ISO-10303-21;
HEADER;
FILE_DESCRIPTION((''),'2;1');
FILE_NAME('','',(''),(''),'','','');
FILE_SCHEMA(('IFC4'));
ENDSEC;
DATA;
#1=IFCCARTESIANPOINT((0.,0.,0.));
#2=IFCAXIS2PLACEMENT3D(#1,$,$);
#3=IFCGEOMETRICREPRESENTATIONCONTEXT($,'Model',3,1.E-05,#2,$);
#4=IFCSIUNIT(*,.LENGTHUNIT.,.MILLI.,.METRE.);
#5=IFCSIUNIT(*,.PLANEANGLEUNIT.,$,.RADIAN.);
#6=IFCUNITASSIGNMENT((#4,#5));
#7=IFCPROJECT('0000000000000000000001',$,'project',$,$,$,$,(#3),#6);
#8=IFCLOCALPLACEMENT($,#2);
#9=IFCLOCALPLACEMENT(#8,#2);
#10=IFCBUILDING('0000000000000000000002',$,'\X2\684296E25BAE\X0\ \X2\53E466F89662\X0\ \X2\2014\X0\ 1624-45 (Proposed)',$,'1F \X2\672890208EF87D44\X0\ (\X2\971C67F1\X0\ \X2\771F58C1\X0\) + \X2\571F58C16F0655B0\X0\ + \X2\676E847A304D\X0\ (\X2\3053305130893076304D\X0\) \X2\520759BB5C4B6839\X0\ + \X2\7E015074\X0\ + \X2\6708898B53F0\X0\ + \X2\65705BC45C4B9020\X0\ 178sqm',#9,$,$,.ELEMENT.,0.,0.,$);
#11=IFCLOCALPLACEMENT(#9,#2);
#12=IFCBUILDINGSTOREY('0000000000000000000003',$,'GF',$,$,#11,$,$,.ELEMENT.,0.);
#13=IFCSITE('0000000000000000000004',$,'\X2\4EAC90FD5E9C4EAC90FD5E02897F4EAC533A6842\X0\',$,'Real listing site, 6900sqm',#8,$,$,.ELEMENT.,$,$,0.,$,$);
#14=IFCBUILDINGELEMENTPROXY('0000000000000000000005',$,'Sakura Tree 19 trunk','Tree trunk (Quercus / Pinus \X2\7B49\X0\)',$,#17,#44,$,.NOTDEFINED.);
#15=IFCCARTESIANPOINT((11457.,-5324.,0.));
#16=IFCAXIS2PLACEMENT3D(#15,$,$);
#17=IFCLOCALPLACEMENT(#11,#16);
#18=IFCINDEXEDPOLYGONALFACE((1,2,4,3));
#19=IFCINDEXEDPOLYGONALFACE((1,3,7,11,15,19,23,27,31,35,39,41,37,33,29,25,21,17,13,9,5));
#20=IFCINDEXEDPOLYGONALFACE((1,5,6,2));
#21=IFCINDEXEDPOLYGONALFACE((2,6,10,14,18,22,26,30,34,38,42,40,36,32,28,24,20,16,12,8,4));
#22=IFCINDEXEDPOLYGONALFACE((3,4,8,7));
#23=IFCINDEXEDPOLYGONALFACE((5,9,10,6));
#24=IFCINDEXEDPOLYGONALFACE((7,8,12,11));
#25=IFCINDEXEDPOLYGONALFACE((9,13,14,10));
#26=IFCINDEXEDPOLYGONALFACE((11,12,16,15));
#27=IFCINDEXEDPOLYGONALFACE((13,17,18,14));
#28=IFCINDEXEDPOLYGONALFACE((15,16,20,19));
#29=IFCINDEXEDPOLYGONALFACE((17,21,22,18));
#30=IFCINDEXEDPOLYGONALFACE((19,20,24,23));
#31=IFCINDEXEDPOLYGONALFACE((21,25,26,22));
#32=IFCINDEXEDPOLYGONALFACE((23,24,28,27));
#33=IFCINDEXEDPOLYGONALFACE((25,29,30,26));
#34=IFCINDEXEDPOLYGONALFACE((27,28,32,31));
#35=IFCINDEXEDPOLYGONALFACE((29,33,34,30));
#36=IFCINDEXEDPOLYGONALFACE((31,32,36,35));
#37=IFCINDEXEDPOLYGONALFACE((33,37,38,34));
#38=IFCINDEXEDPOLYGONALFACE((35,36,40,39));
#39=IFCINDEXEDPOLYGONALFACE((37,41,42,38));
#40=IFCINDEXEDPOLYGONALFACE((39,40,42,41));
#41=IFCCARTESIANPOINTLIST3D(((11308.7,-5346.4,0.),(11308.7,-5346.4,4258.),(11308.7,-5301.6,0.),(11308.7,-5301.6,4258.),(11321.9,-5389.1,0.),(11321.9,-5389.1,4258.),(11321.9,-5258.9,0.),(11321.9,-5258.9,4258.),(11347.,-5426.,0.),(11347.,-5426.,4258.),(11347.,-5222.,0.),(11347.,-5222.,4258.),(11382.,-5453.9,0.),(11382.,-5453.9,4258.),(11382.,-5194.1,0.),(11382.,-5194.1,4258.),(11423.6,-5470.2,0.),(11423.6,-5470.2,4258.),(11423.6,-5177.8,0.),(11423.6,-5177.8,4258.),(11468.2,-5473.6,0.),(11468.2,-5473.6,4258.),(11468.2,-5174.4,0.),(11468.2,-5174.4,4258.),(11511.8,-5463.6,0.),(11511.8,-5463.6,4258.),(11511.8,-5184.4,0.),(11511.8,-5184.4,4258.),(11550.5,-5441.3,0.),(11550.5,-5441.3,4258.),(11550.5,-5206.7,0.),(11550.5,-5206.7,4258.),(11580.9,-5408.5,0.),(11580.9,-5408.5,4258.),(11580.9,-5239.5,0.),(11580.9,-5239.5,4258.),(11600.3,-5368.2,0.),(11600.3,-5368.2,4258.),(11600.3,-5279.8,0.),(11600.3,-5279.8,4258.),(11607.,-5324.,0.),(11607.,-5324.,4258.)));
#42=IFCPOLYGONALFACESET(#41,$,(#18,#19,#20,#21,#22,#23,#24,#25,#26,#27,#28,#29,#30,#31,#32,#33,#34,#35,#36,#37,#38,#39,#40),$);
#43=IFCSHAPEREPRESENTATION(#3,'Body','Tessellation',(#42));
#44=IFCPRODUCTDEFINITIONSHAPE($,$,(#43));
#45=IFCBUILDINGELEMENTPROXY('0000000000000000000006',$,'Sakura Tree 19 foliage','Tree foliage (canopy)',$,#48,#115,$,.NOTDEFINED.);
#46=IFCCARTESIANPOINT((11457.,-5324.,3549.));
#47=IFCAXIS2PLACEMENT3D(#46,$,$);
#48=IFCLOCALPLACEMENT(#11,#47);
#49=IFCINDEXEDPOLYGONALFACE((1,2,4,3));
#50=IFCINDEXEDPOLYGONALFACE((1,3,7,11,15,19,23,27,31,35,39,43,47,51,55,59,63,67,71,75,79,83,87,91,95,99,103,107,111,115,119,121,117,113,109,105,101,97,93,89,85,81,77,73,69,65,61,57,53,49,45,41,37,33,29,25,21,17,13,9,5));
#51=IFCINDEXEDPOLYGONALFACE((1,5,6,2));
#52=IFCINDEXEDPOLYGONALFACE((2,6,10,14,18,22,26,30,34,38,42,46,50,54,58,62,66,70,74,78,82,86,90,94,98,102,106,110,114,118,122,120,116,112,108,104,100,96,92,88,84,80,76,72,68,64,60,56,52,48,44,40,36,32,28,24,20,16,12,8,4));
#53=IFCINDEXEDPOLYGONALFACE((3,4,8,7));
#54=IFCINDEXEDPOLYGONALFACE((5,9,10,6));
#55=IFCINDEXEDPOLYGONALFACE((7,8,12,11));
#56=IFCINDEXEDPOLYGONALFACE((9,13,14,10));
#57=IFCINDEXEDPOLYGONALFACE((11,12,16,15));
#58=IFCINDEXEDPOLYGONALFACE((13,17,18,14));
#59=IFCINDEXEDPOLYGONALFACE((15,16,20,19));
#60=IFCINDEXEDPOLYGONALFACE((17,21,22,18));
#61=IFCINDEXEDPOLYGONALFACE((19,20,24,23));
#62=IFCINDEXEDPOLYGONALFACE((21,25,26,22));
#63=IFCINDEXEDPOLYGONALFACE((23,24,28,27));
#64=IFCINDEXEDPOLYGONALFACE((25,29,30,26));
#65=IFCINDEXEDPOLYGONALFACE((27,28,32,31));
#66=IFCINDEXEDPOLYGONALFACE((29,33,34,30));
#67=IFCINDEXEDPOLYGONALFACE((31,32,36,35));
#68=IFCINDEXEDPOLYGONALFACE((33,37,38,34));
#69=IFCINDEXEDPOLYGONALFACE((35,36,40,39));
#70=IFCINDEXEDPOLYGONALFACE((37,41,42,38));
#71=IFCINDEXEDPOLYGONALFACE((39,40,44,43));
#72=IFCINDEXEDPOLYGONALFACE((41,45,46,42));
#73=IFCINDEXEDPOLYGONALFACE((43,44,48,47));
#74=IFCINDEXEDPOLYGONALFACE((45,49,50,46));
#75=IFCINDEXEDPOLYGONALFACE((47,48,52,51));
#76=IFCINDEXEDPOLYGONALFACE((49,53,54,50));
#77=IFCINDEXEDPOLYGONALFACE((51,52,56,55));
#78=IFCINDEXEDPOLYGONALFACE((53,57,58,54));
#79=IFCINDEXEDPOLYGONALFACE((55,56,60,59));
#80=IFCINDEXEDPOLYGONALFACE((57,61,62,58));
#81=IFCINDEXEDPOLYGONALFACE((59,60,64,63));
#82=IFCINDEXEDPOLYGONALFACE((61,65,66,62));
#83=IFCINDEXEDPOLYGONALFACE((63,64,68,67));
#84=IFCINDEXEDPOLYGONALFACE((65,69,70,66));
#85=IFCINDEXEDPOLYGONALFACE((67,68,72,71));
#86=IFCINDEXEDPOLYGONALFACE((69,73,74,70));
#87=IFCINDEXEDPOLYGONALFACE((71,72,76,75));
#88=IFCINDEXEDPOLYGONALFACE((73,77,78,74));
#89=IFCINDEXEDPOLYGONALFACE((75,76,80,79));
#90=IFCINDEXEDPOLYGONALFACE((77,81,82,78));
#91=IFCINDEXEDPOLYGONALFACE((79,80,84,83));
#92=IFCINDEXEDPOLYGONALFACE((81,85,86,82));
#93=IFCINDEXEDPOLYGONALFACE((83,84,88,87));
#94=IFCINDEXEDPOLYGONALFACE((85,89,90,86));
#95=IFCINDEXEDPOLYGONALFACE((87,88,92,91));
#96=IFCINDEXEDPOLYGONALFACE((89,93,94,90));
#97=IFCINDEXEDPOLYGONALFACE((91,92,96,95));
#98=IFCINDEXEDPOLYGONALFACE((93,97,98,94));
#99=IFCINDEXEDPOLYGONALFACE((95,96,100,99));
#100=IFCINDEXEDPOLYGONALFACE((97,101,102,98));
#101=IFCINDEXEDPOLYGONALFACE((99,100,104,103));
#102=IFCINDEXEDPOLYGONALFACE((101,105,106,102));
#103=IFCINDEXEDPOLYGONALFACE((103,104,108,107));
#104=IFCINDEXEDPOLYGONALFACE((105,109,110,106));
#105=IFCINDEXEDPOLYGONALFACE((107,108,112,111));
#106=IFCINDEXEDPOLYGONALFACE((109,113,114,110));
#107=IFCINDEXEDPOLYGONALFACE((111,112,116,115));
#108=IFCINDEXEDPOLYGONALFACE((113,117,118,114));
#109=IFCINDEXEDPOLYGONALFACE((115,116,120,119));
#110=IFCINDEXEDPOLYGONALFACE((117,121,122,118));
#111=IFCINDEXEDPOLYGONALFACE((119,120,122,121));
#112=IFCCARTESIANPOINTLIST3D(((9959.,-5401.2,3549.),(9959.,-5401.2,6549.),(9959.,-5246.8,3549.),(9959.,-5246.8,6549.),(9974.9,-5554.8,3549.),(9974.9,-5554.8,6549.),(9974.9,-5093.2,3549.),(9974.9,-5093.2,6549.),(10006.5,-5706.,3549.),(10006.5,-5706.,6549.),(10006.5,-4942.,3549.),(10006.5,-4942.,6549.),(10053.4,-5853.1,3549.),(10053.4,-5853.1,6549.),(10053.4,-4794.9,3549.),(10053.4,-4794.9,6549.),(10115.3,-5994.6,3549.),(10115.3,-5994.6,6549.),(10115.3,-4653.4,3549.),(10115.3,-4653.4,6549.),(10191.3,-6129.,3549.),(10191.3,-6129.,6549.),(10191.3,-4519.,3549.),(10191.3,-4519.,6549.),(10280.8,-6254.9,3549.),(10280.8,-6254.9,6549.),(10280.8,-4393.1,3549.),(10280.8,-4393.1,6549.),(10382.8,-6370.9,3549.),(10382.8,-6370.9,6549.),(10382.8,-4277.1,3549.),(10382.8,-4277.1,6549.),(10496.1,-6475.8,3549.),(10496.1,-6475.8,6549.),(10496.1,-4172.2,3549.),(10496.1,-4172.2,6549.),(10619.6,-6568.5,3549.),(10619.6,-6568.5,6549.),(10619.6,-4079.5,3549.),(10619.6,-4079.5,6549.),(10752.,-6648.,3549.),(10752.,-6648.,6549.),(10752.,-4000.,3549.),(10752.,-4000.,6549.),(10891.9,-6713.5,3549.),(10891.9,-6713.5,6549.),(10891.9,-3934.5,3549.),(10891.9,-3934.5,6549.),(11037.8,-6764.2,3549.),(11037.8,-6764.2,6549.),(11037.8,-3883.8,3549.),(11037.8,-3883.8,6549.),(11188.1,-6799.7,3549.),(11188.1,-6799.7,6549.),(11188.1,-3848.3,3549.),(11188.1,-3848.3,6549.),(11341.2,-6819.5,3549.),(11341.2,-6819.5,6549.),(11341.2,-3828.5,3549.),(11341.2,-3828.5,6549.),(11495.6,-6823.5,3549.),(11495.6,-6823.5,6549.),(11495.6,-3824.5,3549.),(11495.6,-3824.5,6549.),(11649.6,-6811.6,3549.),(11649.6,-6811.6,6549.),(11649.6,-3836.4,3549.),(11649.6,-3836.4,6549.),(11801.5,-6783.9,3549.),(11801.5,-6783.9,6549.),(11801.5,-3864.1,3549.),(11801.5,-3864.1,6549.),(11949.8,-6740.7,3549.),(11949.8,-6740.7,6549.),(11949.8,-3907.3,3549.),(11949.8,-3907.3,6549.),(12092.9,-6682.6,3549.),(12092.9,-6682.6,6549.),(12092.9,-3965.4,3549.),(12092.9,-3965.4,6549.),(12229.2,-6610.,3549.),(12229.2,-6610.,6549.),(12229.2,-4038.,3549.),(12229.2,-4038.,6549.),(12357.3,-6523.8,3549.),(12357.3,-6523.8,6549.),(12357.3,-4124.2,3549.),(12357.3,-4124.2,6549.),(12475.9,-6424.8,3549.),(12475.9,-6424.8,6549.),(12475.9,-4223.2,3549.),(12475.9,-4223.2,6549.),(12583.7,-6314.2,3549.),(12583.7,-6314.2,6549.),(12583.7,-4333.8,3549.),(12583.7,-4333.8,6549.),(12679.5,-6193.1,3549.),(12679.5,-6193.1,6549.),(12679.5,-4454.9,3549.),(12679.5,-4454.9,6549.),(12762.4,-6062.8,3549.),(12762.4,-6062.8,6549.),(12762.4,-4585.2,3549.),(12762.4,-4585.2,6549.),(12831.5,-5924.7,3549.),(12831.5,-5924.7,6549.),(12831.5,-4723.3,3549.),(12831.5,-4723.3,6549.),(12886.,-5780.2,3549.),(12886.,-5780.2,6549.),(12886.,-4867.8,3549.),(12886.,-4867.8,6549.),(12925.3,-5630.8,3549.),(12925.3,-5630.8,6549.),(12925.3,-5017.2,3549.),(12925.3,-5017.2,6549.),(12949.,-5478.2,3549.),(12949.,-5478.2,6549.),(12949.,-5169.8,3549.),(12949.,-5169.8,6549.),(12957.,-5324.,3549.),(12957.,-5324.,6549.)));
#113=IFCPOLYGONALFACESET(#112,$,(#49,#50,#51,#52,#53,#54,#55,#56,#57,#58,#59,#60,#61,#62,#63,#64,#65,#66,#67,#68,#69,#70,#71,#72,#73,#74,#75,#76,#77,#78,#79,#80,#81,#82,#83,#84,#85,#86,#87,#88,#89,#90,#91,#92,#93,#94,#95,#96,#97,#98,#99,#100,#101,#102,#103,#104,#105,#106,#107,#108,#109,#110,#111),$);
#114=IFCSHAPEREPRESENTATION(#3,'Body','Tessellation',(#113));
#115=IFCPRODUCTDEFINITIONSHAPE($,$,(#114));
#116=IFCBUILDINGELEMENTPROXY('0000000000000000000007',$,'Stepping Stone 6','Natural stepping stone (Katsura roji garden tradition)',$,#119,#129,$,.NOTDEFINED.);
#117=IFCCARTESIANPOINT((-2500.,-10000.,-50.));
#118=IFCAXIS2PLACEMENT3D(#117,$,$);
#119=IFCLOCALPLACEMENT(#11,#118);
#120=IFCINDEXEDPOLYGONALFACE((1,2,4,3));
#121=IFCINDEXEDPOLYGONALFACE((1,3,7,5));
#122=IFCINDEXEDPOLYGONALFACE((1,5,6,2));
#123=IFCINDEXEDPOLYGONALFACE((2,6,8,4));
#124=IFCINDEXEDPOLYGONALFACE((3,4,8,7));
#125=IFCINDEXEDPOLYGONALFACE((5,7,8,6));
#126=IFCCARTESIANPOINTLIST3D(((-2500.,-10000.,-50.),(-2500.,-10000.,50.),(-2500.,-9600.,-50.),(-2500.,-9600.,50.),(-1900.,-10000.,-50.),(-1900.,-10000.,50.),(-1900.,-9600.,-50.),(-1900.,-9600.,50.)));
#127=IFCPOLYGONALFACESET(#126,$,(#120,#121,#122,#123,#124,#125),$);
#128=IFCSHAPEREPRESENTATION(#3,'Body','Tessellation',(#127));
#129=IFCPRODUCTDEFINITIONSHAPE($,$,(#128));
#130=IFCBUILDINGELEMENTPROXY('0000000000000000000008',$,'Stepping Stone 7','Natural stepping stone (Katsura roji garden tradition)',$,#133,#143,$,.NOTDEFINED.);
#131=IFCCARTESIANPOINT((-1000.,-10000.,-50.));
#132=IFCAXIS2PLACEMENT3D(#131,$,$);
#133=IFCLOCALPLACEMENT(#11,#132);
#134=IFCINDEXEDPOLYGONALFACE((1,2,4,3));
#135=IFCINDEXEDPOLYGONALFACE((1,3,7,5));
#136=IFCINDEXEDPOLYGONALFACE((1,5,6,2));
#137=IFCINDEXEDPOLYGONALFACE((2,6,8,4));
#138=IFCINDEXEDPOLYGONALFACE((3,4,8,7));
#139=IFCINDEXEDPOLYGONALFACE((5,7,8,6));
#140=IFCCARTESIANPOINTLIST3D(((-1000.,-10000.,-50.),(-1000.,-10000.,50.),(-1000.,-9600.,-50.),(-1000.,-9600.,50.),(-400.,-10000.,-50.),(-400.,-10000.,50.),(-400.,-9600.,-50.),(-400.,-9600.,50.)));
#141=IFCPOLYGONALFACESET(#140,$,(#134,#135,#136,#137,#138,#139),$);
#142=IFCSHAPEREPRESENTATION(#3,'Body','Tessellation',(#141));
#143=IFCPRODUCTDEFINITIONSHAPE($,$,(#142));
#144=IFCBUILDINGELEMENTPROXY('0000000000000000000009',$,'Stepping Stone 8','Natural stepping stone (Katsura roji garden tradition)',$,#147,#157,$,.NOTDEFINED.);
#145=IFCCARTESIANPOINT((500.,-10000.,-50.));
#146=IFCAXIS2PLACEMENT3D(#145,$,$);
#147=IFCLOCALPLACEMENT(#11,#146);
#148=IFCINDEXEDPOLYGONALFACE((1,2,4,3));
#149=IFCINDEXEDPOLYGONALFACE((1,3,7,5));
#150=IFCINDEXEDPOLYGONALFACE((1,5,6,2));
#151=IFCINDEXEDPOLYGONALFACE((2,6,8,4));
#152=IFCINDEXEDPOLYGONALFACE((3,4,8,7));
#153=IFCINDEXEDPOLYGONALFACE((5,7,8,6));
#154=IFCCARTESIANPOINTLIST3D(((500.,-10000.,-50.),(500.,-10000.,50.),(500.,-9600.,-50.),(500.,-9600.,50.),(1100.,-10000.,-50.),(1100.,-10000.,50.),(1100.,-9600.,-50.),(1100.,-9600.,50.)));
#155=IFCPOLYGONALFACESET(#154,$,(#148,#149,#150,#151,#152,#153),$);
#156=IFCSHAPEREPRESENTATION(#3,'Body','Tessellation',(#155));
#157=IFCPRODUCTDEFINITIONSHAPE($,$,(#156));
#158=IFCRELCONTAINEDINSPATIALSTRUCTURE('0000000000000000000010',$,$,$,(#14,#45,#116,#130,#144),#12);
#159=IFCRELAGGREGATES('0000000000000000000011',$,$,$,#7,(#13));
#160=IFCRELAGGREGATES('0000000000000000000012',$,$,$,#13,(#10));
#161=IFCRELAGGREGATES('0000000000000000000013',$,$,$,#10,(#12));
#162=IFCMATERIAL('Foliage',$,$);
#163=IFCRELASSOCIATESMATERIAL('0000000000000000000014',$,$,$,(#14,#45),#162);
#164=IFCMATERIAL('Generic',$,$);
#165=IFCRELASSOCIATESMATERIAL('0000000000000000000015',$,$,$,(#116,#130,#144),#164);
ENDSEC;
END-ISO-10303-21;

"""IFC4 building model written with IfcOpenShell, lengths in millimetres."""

from ifc_helpers import new_model, si_unit, frame, frame_2d, origin, origin_2d, place, context, project, spatial, rectangle, circle, extrude, material, element, save


model = new_model("IFC4")

# Units and contexts
model_context = context("Model", 3, precision=1e-05, world=origin())
ifc_project = project(units=[si_unit("LENGTHUNIT", "METRE", prefix="MILLI"), si_unit("PLANEANGLEUNIT", "RADIAN")], contexts=[model_context])

# Site, building, storey
site_placement = place(None, origin())
site = spatial("IfcSite", under=ifc_project, at=site_placement, Name="京都府京都市西京区桂", ObjectType="Real listing site, 6900sqm", CompositionType="ELEMENT", RefElevation=0.0)
building_placement = place(site_placement, origin())
building = spatial("IfcBuilding", under=site, at=building_placement, Name="桂離宮 古書院 — 1624-45 (Proposed)", ObjectType="1F 木造軸組 (霜柱 真壁) + 土壁漆喰 + 杮葺き (こけらぶき) 切妻屋根 + 縁側 + 月見台 + 数寄屋造 178sqm", CompositionType="ELEMENT", ElevationOfRefHeight=0.0, ElevationOfTerrain=0.0)
storey_placement = place(building_placement, origin())
storey = spatial("IfcBuildingStorey", under=building, at=storey_placement, Name="GF", CompositionType="ELEMENT", Elevation=0.0)

# Shared definitions
ifc_material_1 = material(Name="Generic")

# Building element proxies
ifc_material_2 = material(Name="Foliage")
proxy_1_placement = place(storey_placement, frame((11457.0, -5324.0, 0.0)))
element("IfcBuildingElementProxy", 1, at=proxy_1_placement, inside=storey, material=ifc_material_2, Name="Sakura Tree 19 trunk", Description="Tree trunk (Quercus / Pinus 等)", PredefinedType="NOTDEFINED", context=model_context, shape_type="SweptSolid", body=[
    extrude(circle(Radius=150.0, at=origin_2d()), frame((11457.0, -5324.0, 0.0)), (0.0, 0.0, 1.0), 4258.0),
])
proxy_2_placement = place(storey_placement, frame((11457.0, -5324.0, 3549.0)))
element("IfcBuildingElementProxy", 2, at=proxy_2_placement, inside=storey, material=ifc_material_2, Name="Sakura Tree 19 foliage", Description="Tree foliage (canopy)", PredefinedType="NOTDEFINED", context=model_context, shape_type="SweptSolid", body=[
    extrude(circle(Radius=1500.0, at=origin_2d()), frame((11457.0, -5324.0, 3549.0)), (0.0, 0.0, 1.0), 3000.0),
])
proxy_3_placement = place(storey_placement, frame((-2500.0, -10000.0, -50.0)))
element("IfcBuildingElementProxy", 3, at=proxy_3_placement, inside=storey, material=ifc_material_1, Name="Stepping Stone 6", Description="Natural stepping stone (Katsura roji garden tradition)", PredefinedType="NOTDEFINED", context=model_context, shape_type="SweptSolid", body=[
    extrude(rectangle(XDim=600.0, YDim=400.0, at=frame_2d((300.0, 200.0))), frame((-2500.0, -10000.0, -50.0)), (0.0, 0.0, 1.0), 100.0),
])
proxy_4_placement = place(storey_placement, frame((-1000.0, -10000.0, -50.0)))
element("IfcBuildingElementProxy", 4, at=proxy_4_placement, inside=storey, material=ifc_material_1, Name="Stepping Stone 7", Description="Natural stepping stone (Katsura roji garden tradition)", PredefinedType="NOTDEFINED", context=model_context, shape_type="SweptSolid", body=[
    extrude(rectangle(XDim=600.0, YDim=400.0, at=frame_2d((300.0, 200.0))), frame((-1000.0, -10000.0, -50.0)), (0.0, 0.0, 1.0), 100.0),
])
proxy_5_placement = place(storey_placement, frame((500.0, -10000.0, -50.0)))
element("IfcBuildingElementProxy", 5, at=proxy_5_placement, inside=storey, material=ifc_material_1, Name="Stepping Stone 8", Description="Natural stepping stone (Katsura roji garden tradition)", PredefinedType="NOTDEFINED", context=model_context, shape_type="SweptSolid", body=[
    extrude(rectangle(XDim=600.0, YDim=400.0, at=frame_2d((300.0, 200.0))), frame((500.0, -10000.0, -50.0)), (0.0, 0.0, 1.0), 100.0),
])

save(model, "model.ifc")
